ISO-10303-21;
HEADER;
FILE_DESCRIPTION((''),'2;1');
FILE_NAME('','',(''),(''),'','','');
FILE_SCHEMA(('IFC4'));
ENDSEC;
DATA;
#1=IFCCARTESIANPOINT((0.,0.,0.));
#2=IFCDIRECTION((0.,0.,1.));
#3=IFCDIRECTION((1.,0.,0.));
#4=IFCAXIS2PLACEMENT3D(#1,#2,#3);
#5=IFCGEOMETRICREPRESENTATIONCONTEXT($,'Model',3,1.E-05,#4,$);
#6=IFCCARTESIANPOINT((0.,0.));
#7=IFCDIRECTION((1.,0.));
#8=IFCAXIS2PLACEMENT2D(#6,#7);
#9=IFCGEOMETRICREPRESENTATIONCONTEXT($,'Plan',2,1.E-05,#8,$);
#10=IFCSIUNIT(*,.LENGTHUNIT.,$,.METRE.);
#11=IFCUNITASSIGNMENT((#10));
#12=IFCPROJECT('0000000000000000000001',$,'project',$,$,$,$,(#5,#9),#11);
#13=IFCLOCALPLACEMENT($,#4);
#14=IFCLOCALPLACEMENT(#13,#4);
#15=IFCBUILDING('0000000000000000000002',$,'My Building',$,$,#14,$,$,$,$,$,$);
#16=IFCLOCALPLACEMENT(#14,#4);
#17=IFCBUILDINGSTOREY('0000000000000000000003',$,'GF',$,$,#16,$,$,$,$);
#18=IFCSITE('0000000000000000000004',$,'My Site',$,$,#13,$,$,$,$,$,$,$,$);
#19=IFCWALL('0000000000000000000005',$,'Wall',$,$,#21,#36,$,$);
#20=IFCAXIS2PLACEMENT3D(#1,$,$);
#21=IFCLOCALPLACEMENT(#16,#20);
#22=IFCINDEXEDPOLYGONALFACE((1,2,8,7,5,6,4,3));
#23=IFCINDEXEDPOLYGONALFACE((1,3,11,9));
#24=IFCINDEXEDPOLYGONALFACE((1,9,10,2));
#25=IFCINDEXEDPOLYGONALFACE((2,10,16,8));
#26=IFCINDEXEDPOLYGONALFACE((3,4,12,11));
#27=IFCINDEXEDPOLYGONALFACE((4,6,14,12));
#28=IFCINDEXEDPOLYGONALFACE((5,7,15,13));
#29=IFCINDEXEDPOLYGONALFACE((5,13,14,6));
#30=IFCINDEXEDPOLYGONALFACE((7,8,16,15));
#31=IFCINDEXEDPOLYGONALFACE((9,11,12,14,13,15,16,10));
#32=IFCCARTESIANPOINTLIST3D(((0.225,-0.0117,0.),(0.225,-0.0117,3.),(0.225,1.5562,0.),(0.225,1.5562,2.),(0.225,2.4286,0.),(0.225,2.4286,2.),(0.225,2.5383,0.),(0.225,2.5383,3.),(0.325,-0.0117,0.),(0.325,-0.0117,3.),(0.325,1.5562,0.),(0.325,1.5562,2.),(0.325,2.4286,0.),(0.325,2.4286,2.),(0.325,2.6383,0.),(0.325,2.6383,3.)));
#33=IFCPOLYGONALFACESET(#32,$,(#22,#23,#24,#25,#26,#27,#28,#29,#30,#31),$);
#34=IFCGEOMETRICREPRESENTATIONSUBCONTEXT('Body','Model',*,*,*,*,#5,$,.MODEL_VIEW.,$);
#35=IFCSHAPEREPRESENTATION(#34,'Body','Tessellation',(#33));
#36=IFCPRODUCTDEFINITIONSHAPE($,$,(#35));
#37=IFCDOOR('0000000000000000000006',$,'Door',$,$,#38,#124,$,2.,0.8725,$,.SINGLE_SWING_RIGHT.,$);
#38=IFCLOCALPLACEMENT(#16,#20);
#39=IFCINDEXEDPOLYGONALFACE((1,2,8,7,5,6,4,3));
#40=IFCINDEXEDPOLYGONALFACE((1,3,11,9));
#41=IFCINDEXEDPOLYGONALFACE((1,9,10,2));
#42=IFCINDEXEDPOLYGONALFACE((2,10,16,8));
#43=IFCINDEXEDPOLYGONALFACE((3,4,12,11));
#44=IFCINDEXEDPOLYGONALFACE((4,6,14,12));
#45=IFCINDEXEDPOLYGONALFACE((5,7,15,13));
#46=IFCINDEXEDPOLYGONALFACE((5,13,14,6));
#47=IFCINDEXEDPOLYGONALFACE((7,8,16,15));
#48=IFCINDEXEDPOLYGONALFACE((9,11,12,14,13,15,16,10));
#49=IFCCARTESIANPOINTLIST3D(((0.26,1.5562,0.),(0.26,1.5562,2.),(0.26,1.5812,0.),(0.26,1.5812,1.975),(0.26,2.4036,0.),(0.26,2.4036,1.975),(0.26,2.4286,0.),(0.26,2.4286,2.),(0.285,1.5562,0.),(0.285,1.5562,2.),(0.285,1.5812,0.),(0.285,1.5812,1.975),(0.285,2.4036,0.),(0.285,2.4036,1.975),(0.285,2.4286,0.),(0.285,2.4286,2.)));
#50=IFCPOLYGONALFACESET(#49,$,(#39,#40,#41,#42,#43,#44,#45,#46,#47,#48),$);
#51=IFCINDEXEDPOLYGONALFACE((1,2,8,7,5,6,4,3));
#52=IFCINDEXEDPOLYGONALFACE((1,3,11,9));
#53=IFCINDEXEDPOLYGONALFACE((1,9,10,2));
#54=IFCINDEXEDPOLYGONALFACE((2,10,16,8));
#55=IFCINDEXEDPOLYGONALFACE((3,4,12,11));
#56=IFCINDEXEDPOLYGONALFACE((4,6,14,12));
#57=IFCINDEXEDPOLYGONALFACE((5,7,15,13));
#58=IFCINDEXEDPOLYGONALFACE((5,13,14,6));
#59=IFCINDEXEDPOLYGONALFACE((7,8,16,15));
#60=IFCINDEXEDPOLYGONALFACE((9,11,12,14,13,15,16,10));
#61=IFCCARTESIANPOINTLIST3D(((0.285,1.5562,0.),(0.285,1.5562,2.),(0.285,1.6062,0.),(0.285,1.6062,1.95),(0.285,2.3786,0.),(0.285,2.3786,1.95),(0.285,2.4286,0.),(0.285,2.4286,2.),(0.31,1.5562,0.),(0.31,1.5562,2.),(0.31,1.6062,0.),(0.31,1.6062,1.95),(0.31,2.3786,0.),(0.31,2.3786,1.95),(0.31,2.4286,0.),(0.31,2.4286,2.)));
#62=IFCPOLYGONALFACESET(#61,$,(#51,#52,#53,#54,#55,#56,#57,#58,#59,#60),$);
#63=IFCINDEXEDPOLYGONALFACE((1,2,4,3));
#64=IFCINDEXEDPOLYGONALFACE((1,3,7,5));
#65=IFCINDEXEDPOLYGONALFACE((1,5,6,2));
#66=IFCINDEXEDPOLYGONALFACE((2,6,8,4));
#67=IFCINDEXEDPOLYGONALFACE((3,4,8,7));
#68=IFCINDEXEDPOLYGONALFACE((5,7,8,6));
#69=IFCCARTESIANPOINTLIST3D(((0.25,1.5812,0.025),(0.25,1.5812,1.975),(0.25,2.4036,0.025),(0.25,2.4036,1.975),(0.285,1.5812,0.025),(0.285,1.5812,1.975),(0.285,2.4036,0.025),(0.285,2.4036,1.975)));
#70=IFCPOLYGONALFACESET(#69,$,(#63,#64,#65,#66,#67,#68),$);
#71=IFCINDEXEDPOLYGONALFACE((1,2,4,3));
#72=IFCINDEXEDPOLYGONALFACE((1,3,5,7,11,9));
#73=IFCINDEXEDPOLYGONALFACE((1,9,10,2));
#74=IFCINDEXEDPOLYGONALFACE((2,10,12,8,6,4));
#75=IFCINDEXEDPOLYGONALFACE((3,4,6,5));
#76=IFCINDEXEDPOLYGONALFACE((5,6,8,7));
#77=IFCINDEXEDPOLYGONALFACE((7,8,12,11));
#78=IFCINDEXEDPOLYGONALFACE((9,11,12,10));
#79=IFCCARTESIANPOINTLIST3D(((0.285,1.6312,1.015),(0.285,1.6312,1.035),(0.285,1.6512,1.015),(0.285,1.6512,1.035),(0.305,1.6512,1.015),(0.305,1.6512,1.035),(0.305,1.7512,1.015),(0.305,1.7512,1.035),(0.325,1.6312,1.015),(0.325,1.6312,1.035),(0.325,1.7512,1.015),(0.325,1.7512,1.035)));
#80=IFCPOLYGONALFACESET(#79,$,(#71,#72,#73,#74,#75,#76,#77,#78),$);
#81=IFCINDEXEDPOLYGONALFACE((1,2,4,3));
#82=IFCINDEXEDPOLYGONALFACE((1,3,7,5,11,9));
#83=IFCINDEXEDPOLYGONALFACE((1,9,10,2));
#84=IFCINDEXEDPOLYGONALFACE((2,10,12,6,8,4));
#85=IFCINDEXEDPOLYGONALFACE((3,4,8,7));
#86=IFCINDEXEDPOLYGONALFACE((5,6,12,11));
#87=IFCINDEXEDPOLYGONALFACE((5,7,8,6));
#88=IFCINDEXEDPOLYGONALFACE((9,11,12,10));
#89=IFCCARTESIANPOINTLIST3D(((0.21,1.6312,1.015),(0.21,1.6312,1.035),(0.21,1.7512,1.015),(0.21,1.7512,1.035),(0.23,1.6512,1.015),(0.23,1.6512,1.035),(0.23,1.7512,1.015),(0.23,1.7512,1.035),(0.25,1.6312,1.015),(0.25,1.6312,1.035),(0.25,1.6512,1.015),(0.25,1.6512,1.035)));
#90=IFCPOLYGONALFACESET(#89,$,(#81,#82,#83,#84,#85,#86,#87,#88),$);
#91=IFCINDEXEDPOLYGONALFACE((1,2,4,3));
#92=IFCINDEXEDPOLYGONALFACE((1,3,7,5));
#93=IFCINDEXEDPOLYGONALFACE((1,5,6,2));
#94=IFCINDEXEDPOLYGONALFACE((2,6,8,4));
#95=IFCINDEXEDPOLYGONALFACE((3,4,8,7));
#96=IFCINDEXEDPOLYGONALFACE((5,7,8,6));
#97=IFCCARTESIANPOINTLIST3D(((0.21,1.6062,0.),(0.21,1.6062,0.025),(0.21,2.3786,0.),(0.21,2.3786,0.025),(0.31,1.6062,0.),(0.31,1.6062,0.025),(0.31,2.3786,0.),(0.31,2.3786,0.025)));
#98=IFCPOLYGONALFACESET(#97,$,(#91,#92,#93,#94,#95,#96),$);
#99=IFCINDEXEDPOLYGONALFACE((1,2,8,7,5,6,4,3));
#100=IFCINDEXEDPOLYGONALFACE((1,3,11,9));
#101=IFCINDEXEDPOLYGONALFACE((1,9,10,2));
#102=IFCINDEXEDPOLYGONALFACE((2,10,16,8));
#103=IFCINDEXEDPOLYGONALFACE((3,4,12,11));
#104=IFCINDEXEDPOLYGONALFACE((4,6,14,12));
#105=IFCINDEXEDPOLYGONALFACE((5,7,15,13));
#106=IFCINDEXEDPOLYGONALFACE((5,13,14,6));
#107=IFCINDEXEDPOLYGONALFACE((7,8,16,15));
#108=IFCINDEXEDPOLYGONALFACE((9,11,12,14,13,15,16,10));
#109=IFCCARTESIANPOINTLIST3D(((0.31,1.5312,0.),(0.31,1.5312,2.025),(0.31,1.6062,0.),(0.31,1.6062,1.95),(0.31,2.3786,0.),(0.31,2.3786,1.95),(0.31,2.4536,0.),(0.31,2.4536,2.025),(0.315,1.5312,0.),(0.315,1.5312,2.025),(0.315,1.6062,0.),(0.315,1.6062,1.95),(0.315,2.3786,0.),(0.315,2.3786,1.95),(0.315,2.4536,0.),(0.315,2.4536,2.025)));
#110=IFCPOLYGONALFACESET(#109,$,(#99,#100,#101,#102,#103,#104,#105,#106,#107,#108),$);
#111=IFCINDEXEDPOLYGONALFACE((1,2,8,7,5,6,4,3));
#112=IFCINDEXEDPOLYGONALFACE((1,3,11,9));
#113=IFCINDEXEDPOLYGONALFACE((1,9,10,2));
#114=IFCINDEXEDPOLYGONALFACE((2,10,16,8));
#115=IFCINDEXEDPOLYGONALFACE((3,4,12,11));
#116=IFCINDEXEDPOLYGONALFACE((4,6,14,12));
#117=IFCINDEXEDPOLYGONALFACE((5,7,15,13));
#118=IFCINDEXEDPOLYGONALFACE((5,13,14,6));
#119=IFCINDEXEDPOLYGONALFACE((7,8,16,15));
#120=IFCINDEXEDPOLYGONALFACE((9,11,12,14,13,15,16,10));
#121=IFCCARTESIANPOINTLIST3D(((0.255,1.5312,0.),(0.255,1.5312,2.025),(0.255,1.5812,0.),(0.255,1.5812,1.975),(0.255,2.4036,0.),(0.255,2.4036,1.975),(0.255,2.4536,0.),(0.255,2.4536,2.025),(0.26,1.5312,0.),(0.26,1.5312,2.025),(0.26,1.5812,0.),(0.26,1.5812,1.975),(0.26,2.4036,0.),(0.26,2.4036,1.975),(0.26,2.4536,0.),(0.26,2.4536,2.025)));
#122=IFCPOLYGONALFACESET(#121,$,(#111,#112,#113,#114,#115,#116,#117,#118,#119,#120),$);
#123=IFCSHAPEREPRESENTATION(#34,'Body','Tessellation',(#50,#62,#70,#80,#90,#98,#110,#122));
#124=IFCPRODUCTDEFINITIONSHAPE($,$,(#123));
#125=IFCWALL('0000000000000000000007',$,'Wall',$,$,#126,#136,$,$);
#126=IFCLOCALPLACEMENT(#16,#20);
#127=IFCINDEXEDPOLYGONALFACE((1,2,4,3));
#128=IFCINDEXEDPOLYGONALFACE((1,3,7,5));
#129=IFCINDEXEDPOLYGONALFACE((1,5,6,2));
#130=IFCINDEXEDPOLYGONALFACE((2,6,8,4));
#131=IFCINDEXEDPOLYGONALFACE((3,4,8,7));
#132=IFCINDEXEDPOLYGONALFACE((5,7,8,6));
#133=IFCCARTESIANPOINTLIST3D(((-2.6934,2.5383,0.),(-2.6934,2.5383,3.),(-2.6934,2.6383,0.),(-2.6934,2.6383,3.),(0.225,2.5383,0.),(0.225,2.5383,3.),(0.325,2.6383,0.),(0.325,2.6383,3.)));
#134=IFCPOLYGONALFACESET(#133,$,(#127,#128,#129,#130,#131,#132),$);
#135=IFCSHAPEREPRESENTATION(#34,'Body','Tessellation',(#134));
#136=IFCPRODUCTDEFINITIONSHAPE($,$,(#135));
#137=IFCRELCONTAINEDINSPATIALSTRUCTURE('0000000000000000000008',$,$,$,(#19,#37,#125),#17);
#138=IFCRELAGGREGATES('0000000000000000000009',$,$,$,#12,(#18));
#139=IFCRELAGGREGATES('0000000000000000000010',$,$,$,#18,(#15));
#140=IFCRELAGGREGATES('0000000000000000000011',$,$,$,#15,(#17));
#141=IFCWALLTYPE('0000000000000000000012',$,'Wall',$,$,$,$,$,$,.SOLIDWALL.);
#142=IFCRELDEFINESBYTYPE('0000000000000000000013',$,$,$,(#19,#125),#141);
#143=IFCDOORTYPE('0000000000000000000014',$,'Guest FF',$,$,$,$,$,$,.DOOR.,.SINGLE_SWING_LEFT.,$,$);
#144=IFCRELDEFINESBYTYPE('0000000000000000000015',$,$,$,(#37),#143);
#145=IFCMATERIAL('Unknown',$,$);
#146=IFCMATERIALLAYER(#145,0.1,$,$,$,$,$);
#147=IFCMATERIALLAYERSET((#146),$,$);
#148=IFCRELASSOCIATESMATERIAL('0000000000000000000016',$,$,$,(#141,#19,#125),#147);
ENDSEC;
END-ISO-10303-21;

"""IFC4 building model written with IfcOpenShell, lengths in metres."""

from ifc_helpers import new_model, entity, si_unit, frame, origin_with_axes, origin_2d_with_axis, place, context, subcontext, project, spatial, line, indexed_curve, outline, extrude, shape, source, transform, mapped, material, layer, layer_set, layer_usage, type_object, type_shapes, element, fill, save


model = new_model("IFC4")

# Units and contexts
model_context = context("Model", 3, precision=1e-05, world=origin_with_axes())
plan_context = context("Plan", 2, precision=1e-05, world=origin_2d_with_axis())
body_context_1 = subcontext(model_context, "Body", "Model", "MODEL_VIEW")
body_context_2 = subcontext(plan_context, "Body", "Plan", "PLAN_VIEW")
ifc_project = project(units=[si_unit("LENGTHUNIT", "METRE")], contexts=[model_context, plan_context])

# Site, building, storey
site_placement = place(None, origin_with_axes())
site = spatial("IfcSite", under=ifc_project, at=site_placement, Name="My Site")
building_placement = place(site_placement, origin_with_axes())
building = spatial("IfcBuilding", under=site, at=building_placement, Name="My Building")
storey_placement = place(building_placement, origin_with_axes())
storey = spatial("IfcBuildingStorey", under=building, at=storey_placement, Name="GF")

# Shared definitions
ifc_material_1 = material(Name="Unknown")

# Shared definitions
ifc_layer_1 = layer(ifc_material_1, 0.1)
ifc_layer_set_1 = layer_set([ifc_layer_1])
wall_type = type_object("IfcWallType", Name="Wall", PredefinedType="SOLIDWALL", material=ifc_layer_set_1)

# Wall, opening, door
ifc_layer_usage_1 = layer_usage(ifc_layer_set_1, "AXIS2", "POSITIVE", 0.0)
wall_1_placement = place(storey_placement, frame((0.325, -0.0117, 0.0), z_axis=(0.0, 0.0, 1.0), x_axis=(0.0, 1.0, 0.0)))
wall_1 = element("IfcWall", 1, at=wall_1_placement, inside=storey, type_object=wall_type, material=ifc_layer_usage_1, Name="Wall", context=body_context_1, shape_type="SweptSolid", body=[
    extrude(outline(indexed_curve([(0.0, 0.0), (0.0, 0.1), (2.55, 0.1), (2.65, 0.0)], segments=[line(1, 2, 3, 4, 1)])), origin_with_axes(), (0.0, 0.0, 1.0), 3.0),
])
shared_shape_1 = source(origin_with_axes(), body_context_1, "Body", "SweptSolid", [
    extrude(outline(indexed_curve([(0.0, 0.0), (0.8725, 0.0), (0.8725, 2.0), (0.0, 2.0)], segments=[line(1, 2, 3, 4, 1)])), frame((0.0, -0.6, 0.0), z_axis=(0.0, -1.0, 0.0), x_axis=(1.0, 0.0, 0.0)), (0.0, 0.0, -1.0), 1.2),
])
opening_1_placement = place(wall_1_placement, frame((1.5679, 0.015, 0.0), z_axis=(0.0, 0.0, 1.0), x_axis=(1.0, 0.0, 0.0)))
opening_1 = element("IfcOpeningElement", 2, at=opening_1_placement, cuts=wall_1, PredefinedType="OPENING", context=body_context_1, shape_type="MappedRepresentation", body=[
    mapped(shared_shape_1, transform((0.0, 0.0, 0.0), x_axis=(1.0, 0.0, 0.0), y_axis=(0.0, 1.0, 0.0), z_axis=(0.0, 0.0, 1.0), scale=1.0)),
])
door_type_1 = type_object("IfcDoorType", Name="Guest FF", OperationType="SINGLE_SWING_LEFT", PredefinedType="DOOR")
shared_shape_2 = source(origin_with_axes(), body_context_1, "Body", "SweptSolid", [
    extrude(outline(indexed_curve([(0.0, 0.0), (0.0, 2.0), (0.8725, 2.0), (0.8725, 0.0), (0.8475, 0.0), (0.8475, 1.975), (0.025, 1.975), (0.025, 0.0)], segments=[line(1, 2, 3, 4, 5, 6, 7, 8, 1)])), frame((0.0, 0.025, 0.0), z_axis=(0.0, -1.0, 0.0), x_axis=(1.0, 0.0, 0.0)), (0.0, 0.0, -1.0), 0.025),
    extrude(outline(indexed_curve([(0.0, 0.0), (0.0, 2.0), (0.8725, 2.0), (0.8725, 0.0), (0.8225, 0.0), (0.8225, 1.95), (0.05, 1.95), (0.05, 0.0)], segments=[line(1, 2, 3, 4, 5, 6, 7, 8, 1)])), frame((0.0, 0.0, 0.0), z_axis=(0.0, -1.0, 0.0), x_axis=(1.0, 0.0, 0.0)), (0.0, 0.0, -1.0), 0.025),
    extrude(outline(indexed_curve([(0.0, 0.0), (0.8225, 0.0), (0.8225, 0.035), (0.0, 0.035)], segments=[line(1, 2, 3, 4, 1)])), frame((0.025, 0.025, 0.025), z_axis=(0.0, 0.0, 1.0), x_axis=(1.0, 0.0, 0.0)), (0.0, 0.0, 1.0), 1.95),
    extrude(outline(indexed_curve([(0.0, 0.0), (0.0, -0.04), (0.12, -0.04), (0.12, -0.02), (0.02, -0.02), (0.02, 0.0)], segments=[line(1, 2, 3, 4, 5, 6, 1)])), frame((0.075, 0.025, 1.015), z_axis=(0.0, 0.0, 1.0), x_axis=(1.0, 0.0, 0.0)), (0.0, 0.0, 1.0), 0.02),
    extrude(outline(indexed_curve([(0.0, 0.0), (0.0, 0.04), (0.12, 0.04), (0.12, 0.02), (0.02, 0.02), (0.02, 0.0)], segments=[line(1, 2, 3, 4, 5, 6, 1)])), frame((0.075, 0.06, 1.015), z_axis=(0.0, 0.0, 1.0), x_axis=(1.0, 0.0, 0.0)), (0.0, 0.0, 1.0), 0.02),
    extrude(outline(indexed_curve([(0.0, 0.0), (0.7725, 0.0), (0.7725, 0.1), (0.0, 0.1)], segments=[line(1, 2, 3, 4, 1)])), frame((0.05, 0.0, 0.0), z_axis=(0.0, 0.0, 1.0), x_axis=(1.0, 0.0, 0.0)), (0.0, 0.0, 1.0), 0.025),
    extrude(outline(indexed_curve([(0.0, 0.0), (0.0, 2.025), (0.9225, 2.025), (0.9225, 0.0), (0.8475, 0.0), (0.8475, 1.95), (0.075, 1.95), (0.075, 0.0)], segments=[line(1, 2, 3, 4, 5, 6, 7, 8, 1)])), frame((-0.025, -0.005, 0.0), z_axis=(0.0, -1.0, 0.0), x_axis=(1.0, 0.0, 0.0)), (0.0, 0.0, -1.0), 0.005),
    extrude(outline(indexed_curve([(0.0, 0.0), (0.0, 2.025), (0.9225, 2.025), (0.9225, 0.0), (0.8725, 0.0), (0.8725, 1.975), (0.05, 1.975), (0.05, 0.0)], segments=[line(1, 2, 3, 4, 5, 6, 7, 8, 1)])), frame((-0.025, 0.05, 0.0), z_axis=(0.0, -1.0, 0.0), x_axis=(1.0, 0.0, 0.0)), (0.0, 0.0, -1.0), 0.005),
])
shared_shape_3 = source(origin_with_axes(), body_context_2, "Body", "Curve2D", [
    entity("IfcIndexedPolyCurve", entity("IfcCartesianPointList2D", [[0.0, 0.0], [0.0, 0.05], [0.025, 0.05], [0.025, 0.025], [0.05, 0.025], [0.05, 0.0]]), [entity("IfcLineIndex", [1, 2, 3, 4, 5, 6, 1])]),
    entity("IfcIndexedPolyCurve", entity("IfcCartesianPointList2D", [[0.8725, 0.0], [0.8725, 0.05], [0.8475, 0.05], [0.8475, 0.025], [0.8225, 0.025], [0.8225, 0.0]]), [entity("IfcLineIndex", [1, 2, 3, 4, 5, 6, 1])]),
    entity("IfcTrimmedCurve", entity("IfcEllipse", entity("IfcAxis2Placement2D", entity("IfcCartesianPoint", [0.8125, 0.05]), entity("IfcDirection", [1.0, 0.0])), 0.7875, 0.8225), [entity("IfcCartesianPoint", [0.8125, 0.8725])], [entity("IfcCartesianPoint", [0.025, 0.05])], True, "CARTESIAN"),
    entity("IfcIndexedPolyCurve", entity("IfcCartesianPointList2D", [[0.8475, 0.05], [0.8125, 0.05], [0.8125, 0.8725], [0.8475, 0.8725]]), [entity("IfcLineIndex", [1, 2, 3, 4, 1])]),
])
type_shapes(door_type_1, [shared_shape_2, shared_shape_3])
door_1_placement = place(opening_1_placement, frame((0.0, 0.0, 0.0), z_axis=(0.0, 0.0, 1.0), x_axis=(1.0, 0.0, 0.0)))
door_1 = element("IfcDoor", 3, at=door_1_placement, inside=storey, type_object=door_type_1, Name="Door", OperationType="SINGLE_SWING_RIGHT", OverallHeight=2.0, OverallWidth=0.8725, shapes=[
    shape(body_context_1, "Body", "MappedRepresentation", [mapped(shared_shape_2, transform((0.0, 0.0, 0.0), x_axis=(1.0, 0.0, 0.0), y_axis=(0.0, 1.0, 0.0), z_axis=(0.0, 0.0, 1.0), scale=1.0))]),
    shape(body_context_2, "Body", "MappedRepresentation", [mapped(shared_shape_3, transform((0.0, 0.0, 0.0), x_axis=(1.0, 0.0, 0.0), y_axis=(0.0, 1.0, 0.0), z_axis=(0.0, 0.0, 1.0), scale=1.0))]),
])
fill(opening_1, door_1)

# Wall
ifc_layer_usage_2 = layer_usage(ifc_layer_set_1, "AXIS2", "POSITIVE", 0.0)
wall_2_placement = place(storey_placement, frame((0.325, 2.6383, 0.0), z_axis=(0.0, 0.0, 1.0), x_axis=(-1.0, 0.0, 0.0)))
element("IfcWall", 4, at=wall_2_placement, inside=storey, type_object=wall_type, material=ifc_layer_usage_2, Name="Wall", context=body_context_1, shape_type="SweptSolid", body=[
    extrude(outline(indexed_curve([(0.0, 0.0), (0.1, 0.1), (3.0184, 0.1), (3.0184, 0.0)], segments=[line(1, 2, 3, 4, 1)])), origin_with_axes(), (0.0, 0.0, 1.0), 3.0),
])

save(model, "model.ifc")
